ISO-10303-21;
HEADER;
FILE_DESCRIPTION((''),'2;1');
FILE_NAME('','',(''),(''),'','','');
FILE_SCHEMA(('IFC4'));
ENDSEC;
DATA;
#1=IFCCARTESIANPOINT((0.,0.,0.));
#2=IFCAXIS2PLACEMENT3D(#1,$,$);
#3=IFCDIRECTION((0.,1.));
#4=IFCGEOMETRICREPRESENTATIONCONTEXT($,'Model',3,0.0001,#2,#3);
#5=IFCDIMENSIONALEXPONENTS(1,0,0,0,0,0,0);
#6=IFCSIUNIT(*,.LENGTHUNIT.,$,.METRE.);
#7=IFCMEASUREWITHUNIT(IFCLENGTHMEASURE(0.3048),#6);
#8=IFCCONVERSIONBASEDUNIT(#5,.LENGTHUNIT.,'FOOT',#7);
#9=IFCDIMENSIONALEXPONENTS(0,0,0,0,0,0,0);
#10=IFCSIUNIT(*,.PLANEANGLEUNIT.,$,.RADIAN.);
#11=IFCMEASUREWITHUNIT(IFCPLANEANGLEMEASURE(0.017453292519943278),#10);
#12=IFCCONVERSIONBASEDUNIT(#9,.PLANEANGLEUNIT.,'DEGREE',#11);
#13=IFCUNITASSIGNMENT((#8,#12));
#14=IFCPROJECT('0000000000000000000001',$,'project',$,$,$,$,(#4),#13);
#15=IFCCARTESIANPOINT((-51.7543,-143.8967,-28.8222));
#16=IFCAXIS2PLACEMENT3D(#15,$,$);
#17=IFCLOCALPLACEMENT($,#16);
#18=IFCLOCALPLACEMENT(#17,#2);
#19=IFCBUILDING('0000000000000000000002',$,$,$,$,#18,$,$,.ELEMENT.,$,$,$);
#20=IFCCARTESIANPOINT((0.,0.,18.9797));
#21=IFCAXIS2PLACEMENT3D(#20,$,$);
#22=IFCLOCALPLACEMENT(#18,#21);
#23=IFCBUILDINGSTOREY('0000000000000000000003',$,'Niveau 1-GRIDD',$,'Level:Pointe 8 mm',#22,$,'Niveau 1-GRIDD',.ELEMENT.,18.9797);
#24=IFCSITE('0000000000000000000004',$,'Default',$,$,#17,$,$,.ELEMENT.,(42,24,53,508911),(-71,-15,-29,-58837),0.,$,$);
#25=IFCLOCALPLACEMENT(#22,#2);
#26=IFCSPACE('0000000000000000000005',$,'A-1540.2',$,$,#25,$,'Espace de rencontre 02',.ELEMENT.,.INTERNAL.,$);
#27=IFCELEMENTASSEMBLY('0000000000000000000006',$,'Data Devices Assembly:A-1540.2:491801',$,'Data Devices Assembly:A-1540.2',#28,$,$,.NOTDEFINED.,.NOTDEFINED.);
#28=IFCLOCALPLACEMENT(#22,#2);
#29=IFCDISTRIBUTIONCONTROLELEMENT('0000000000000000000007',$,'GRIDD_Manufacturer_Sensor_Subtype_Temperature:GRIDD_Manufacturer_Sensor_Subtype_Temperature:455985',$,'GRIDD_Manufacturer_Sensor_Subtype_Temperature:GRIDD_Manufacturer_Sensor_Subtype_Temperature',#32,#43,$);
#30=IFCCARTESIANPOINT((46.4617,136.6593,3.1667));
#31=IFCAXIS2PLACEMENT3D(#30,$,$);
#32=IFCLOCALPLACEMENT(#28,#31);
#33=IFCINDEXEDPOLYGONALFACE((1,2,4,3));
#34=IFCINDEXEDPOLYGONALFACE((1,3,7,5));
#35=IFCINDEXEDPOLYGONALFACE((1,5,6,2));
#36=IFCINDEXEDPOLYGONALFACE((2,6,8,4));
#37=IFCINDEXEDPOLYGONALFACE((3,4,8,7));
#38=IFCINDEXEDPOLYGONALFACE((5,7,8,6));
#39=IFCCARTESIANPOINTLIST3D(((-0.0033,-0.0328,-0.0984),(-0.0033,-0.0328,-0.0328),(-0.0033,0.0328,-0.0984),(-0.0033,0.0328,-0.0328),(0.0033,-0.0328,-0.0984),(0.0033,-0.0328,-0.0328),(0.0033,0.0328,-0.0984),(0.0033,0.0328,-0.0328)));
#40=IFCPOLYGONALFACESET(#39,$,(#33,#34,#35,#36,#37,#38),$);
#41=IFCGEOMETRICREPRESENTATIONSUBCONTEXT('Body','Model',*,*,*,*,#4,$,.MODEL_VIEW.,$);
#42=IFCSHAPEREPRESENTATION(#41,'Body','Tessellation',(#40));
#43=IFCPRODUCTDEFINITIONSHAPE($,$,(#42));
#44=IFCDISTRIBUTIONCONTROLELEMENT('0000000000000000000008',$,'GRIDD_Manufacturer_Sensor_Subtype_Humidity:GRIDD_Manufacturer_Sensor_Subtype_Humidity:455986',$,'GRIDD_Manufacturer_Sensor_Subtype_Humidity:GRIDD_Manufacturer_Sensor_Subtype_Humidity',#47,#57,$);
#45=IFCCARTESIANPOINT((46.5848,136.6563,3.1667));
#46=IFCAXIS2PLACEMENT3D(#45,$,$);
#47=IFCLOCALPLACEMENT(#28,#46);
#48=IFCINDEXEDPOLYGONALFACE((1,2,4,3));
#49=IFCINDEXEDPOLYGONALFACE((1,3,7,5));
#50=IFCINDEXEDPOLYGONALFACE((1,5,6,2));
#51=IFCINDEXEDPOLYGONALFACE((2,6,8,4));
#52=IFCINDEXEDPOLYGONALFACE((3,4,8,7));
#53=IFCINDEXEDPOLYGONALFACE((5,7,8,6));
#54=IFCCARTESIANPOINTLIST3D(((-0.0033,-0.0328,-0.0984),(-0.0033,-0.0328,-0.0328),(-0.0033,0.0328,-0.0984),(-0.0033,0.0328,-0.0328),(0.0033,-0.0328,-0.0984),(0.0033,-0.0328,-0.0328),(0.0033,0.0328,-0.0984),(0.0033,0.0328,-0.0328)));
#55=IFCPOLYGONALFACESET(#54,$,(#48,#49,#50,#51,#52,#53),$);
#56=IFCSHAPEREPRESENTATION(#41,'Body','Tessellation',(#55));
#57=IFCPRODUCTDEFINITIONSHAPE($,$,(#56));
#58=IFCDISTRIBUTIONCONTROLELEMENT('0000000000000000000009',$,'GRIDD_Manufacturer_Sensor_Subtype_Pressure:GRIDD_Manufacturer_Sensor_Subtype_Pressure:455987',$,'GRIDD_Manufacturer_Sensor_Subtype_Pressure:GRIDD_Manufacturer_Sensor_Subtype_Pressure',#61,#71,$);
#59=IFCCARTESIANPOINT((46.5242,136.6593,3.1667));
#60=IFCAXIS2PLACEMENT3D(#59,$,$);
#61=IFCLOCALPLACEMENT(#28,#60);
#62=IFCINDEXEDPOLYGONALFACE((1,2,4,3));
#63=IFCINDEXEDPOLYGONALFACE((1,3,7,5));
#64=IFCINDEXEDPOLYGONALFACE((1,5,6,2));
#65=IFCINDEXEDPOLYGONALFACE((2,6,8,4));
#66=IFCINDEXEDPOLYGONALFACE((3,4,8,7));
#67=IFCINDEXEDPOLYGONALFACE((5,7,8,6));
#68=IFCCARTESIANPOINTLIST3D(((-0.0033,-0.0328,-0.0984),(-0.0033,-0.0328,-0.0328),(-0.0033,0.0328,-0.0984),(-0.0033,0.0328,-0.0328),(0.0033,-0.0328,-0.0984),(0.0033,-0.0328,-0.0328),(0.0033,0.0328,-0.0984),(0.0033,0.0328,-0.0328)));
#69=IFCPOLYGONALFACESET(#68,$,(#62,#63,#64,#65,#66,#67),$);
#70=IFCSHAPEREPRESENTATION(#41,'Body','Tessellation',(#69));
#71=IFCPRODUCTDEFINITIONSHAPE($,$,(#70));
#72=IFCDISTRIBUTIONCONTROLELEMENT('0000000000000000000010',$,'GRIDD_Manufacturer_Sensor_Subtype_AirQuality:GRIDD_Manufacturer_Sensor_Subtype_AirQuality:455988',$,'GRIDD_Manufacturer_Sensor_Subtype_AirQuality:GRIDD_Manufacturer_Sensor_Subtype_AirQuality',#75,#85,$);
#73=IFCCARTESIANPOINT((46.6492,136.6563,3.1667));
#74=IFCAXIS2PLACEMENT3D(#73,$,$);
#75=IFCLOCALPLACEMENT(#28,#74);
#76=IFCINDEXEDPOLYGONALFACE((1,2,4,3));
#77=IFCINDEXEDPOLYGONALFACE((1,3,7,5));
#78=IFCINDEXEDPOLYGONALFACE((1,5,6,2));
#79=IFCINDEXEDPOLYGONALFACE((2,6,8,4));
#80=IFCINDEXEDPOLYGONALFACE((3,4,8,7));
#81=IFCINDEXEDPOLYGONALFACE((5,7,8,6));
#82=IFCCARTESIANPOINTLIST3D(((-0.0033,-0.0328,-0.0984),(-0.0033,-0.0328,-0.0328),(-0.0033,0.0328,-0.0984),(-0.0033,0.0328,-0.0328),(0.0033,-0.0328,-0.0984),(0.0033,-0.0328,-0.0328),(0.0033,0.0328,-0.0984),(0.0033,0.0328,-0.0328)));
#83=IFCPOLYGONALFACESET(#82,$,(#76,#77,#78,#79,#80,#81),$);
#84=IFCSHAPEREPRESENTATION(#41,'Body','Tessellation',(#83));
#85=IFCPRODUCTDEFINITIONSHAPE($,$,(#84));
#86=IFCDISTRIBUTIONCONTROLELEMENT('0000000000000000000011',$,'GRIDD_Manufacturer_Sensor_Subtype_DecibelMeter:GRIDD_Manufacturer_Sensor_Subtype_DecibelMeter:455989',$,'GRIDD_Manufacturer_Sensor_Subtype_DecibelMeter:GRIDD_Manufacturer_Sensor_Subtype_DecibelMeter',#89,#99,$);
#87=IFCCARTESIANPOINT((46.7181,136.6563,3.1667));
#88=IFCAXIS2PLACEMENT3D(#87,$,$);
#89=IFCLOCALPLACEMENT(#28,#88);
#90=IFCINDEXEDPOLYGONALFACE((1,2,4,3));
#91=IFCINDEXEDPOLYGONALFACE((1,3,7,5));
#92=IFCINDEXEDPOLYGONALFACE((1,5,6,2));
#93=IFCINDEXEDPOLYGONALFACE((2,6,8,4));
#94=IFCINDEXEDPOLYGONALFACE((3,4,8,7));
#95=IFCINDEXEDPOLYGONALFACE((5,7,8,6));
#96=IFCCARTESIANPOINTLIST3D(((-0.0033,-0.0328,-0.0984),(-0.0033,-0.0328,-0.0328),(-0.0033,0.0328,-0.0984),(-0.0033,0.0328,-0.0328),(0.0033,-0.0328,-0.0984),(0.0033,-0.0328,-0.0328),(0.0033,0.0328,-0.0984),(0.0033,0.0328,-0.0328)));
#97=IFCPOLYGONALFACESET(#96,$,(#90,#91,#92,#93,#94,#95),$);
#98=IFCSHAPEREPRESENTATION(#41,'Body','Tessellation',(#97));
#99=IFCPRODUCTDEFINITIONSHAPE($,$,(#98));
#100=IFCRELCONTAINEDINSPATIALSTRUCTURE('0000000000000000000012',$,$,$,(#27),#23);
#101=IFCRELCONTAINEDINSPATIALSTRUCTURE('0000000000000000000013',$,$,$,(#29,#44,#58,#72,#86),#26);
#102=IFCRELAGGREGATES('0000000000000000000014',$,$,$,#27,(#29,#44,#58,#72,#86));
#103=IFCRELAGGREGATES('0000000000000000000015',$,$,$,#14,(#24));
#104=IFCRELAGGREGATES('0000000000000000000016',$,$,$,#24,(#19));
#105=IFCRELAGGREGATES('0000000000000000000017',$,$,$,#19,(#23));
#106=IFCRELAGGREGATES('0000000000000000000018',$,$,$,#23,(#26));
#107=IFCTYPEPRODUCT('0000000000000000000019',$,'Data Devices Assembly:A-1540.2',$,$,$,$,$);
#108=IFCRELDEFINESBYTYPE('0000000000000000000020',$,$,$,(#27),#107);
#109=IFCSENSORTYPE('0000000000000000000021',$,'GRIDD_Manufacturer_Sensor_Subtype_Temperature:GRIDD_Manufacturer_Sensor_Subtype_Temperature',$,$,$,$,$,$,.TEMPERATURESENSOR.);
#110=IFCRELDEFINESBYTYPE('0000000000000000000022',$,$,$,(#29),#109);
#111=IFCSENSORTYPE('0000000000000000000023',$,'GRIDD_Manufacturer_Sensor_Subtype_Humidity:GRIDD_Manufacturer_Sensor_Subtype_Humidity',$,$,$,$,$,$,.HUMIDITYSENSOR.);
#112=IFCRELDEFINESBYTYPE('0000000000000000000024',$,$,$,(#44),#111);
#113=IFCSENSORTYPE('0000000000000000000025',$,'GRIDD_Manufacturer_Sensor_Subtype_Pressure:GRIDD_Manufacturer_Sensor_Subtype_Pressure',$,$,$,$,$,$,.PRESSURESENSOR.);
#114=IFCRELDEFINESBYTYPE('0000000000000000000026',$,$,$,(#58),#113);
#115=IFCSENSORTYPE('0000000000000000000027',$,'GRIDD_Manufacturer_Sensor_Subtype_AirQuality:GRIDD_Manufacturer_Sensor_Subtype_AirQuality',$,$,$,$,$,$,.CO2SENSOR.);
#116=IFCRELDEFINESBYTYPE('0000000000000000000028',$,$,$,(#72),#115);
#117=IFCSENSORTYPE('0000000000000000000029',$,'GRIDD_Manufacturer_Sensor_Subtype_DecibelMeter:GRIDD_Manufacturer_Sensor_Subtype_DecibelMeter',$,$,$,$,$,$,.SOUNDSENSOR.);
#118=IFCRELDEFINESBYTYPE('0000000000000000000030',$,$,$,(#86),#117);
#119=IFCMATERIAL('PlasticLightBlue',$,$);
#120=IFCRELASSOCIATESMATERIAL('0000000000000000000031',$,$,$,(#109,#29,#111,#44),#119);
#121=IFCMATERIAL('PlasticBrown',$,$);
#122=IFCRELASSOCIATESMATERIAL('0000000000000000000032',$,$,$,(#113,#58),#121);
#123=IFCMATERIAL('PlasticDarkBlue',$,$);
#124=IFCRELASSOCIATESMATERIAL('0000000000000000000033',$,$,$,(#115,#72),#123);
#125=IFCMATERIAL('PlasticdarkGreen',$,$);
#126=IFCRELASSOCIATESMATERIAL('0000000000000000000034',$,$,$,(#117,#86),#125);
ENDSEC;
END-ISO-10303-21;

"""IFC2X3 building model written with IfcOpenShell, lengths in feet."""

from ifc_helpers import new_model, entity, si_unit, converted_unit, direction, frame, origin, origin_2d_with_axis, place, context, subcontext, project, spatial, rectangle, extrude, source, transform, mapped, material, type_object, type_shapes, element, aggregate, save


model = new_model("IFC2X3")

# Units and contexts
model_context = context("Model", 3, precision=0.0001, world=origin(), true_north=direction((0.0, 1.0)))
body_context = subcontext(model_context, "Body", "Model", "MODEL_VIEW")
ifc_project = project(units=[converted_unit("LENGTHUNIT", "FOOT", entity("IfcLengthMeasure", 0.3048), si_unit("LENGTHUNIT", "METRE"), dimensions=[1, 0, 0, 0, 0, 0, 0]), converted_unit("PLANEANGLEUNIT", "DEGREE", entity("IfcPlaneAngleMeasure", 0.017453292519943278), si_unit("PLANEANGLEUNIT", "RADIAN"), dimensions=[0, 0, 0, 0, 0, 0, 0])], contexts=[model_context])

# Site, building, storey
site_placement = place(None, frame((-51.7543, -143.8967, -28.8222)))
site = spatial("IfcSite", under=ifc_project, at=site_placement, Name="Default", CompositionType="ELEMENT", RefLatitude=(42, 24, 53, 508911), RefLongitude=(-71, -15, -29, -58837), RefElevation=0.0)
building_placement = place(site_placement, origin())
building = spatial("IfcBuilding", under=site, at=building_placement, CompositionType="ELEMENT")
storey_placement = place(building_placement, frame((0.0, 0.0, 18.9797)))
storey = spatial("IfcBuildingStorey", under=building, at=storey_placement, Name="Niveau 1-GRIDD", ObjectType="Level:Pointe 8 mm", LongName="Niveau 1-GRIDD", CompositionType="ELEMENT", Elevation=18.9797)

# Shared definitions
space_1_placement = place(storey_placement, origin())
space_1 = spatial("IfcSpace", under=storey, at=space_1_placement, Name="A-1540.2", LongName="Espace de rencontre 02", CompositionType="ELEMENT", InteriorOrExteriorSpace="INTERNAL")

# Element assembly, distribution control elements
type_product = type_object("IfcTypeProduct", Name="Data Devices Assembly:A-1540.2")
assembly_placement = place(storey_placement, origin())
assembly = element("IfcElementAssembly", 1, at=assembly_placement, inside=storey, type_object=type_product, Name="Data Devices Assembly:A-1540.2:491801", ObjectType="Data Devices Assembly:A-1540.2", AssemblyPlace="NOTDEFINED", PredefinedType="NOTDEFINED")
ifc_material_1 = material(Name="PlasticLightBlue")
sensor_type_1 = type_object("IfcSensorType", Name="GRIDD_Manufacturer_Sensor_Subtype_Temperature:GRIDD_Manufacturer_Sensor_Subtype_Temperature", PredefinedType="TEMPERATURESENSOR", material=ifc_material_1)
shared_shape_1 = source(origin(), body_context, "Body", "SweptSolid", [
    extrude(rectangle(XDim=0.0066, YDim=0.0656, at=origin_2d_with_axis()), frame((0.0, 0.0, -0.0984), z_axis=(0.0, 0.0, 1.0), x_axis=(-1.0, 0.0, 0.0)), (0.0, 0.0, 1.0), 0.0656),
])
type_shapes(sensor_type_1, [shared_shape_1])
distribution_control_element_1_placement = place(assembly_placement, frame((46.4617, 136.6593, 3.1667)))
distribution_control_element_1 = element("IfcDistributionControlElement", 2, at=distribution_control_element_1_placement, inside=space_1, type_object=sensor_type_1, material=ifc_material_1, Name="GRIDD_Manufacturer_Sensor_Subtype_Temperature:GRIDD_Manufacturer_Sensor_Subtype_Temperature:455985", ObjectType="GRIDD_Manufacturer_Sensor_Subtype_Temperature:GRIDD_Manufacturer_Sensor_Subtype_Temperature", context=body_context, shape_type="MappedRepresentation", body=[
    mapped(shared_shape_1, transform((0.0, 0.0, 0.0), scale=1.0)),
])
sensor_type_2 = type_object("IfcSensorType", Name="GRIDD_Manufacturer_Sensor_Subtype_Humidity:GRIDD_Manufacturer_Sensor_Subtype_Humidity", PredefinedType="HUMIDITYSENSOR", material=ifc_material_1)
shared_shape_2 = source(origin(), body_context, "Body", "SweptSolid", [
    extrude(rectangle(XDim=0.0066, YDim=0.0656, at=origin_2d_with_axis()), frame((0.0, 0.0, -0.0984), z_axis=(0.0, 0.0, 1.0), x_axis=(-1.0, 0.0, 0.0)), (0.0, 0.0, 1.0), 0.0656),
])
type_shapes(sensor_type_2, [shared_shape_2])
distribution_control_element_2_placement = place(assembly_placement, frame((46.5848, 136.6563, 3.1667)))
distribution_control_element_2 = element("IfcDistributionControlElement", 3, at=distribution_control_element_2_placement, inside=space_1, type_object=sensor_type_2, material=ifc_material_1, Name="GRIDD_Manufacturer_Sensor_Subtype_Humidity:GRIDD_Manufacturer_Sensor_Subtype_Humidity:455986", ObjectType="GRIDD_Manufacturer_Sensor_Subtype_Humidity:GRIDD_Manufacturer_Sensor_Subtype_Humidity", context=body_context, shape_type="MappedRepresentation", body=[
    mapped(shared_shape_2, transform((0.0, 0.0, 0.0), scale=1.0)),
])
ifc_material_2 = material(Name="PlasticBrown")
sensor_type_3 = type_object("IfcSensorType", Name="GRIDD_Manufacturer_Sensor_Subtype_Pressure:GRIDD_Manufacturer_Sensor_Subtype_Pressure", PredefinedType="PRESSURESENSOR", material=ifc_material_2)
shared_shape_3 = source(origin(), body_context, "Body", "SweptSolid", [
    extrude(rectangle(XDim=0.0066, YDim=0.0656, at=origin_2d_with_axis()), frame((0.0, 0.0, -0.0984), z_axis=(0.0, 0.0, 1.0), x_axis=(-1.0, 0.0, 0.0)), (0.0, 0.0, 1.0), 0.0656),
])
type_shapes(sensor_type_3, [shared_shape_3])
distribution_control_element_3_placement = place(assembly_placement, frame((46.5242, 136.6593, 3.1667)))
distribution_control_element_3 = element("IfcDistributionControlElement", 4, at=distribution_control_element_3_placement, inside=space_1, type_object=sensor_type_3, material=ifc_material_2, Name="GRIDD_Manufacturer_Sensor_Subtype_Pressure:GRIDD_Manufacturer_Sensor_Subtype_Pressure:455987", ObjectType="GRIDD_Manufacturer_Sensor_Subtype_Pressure:GRIDD_Manufacturer_Sensor_Subtype_Pressure", context=body_context, shape_type="MappedRepresentation", body=[
    mapped(shared_shape_3, transform((0.0, 0.0, 0.0), scale=1.0)),
])
ifc_material_3 = material(Name="PlasticDarkBlue")
sensor_type_4 = type_object("IfcSensorType", Name="GRIDD_Manufacturer_Sensor_Subtype_AirQuality:GRIDD_Manufacturer_Sensor_Subtype_AirQuality", PredefinedType="CO2SENSOR", material=ifc_material_3)
shared_shape_4 = source(origin(), body_context, "Body", "SweptSolid", [
    extrude(rectangle(XDim=0.0066, YDim=0.0656, at=origin_2d_with_axis()), frame((0.0, 0.0, -0.0984), z_axis=(0.0, 0.0, 1.0), x_axis=(-1.0, 0.0, 0.0)), (0.0, 0.0, 1.0), 0.0656),
])
type_shapes(sensor_type_4, [shared_shape_4])
distribution_control_element_4_placement = place(assembly_placement, frame((46.6492, 136.6563, 3.1667)))
distribution_control_element_4 = element("IfcDistributionControlElement", 5, at=distribution_control_element_4_placement, inside=space_1, type_object=sensor_type_4, material=ifc_material_3, Name="GRIDD_Manufacturer_Sensor_Subtype_AirQuality:GRIDD_Manufacturer_Sensor_Subtype_AirQuality:455988", ObjectType="GRIDD_Manufacturer_Sensor_Subtype_AirQuality:GRIDD_Manufacturer_Sensor_Subtype_AirQuality", context=body_context, shape_type="MappedRepresentation", body=[
    mapped(shared_shape_4, transform((0.0, 0.0, 0.0), scale=1.0)),
])
ifc_material_4 = material(Name="PlasticdarkGreen")
sensor_type_5 = type_object("IfcSensorType", Name="GRIDD_Manufacturer_Sensor_Subtype_DecibelMeter:GRIDD_Manufacturer_Sensor_Subtype_DecibelMeter", PredefinedType="SOUNDSENSOR", material=ifc_material_4)
shared_shape_5 = source(origin(), body_context, "Body", "SweptSolid", [
    extrude(rectangle(XDim=0.0066, YDim=0.0656, at=origin_2d_with_axis()), frame((0.0, 0.0, -0.0984), z_axis=(0.0, 0.0, 1.0), x_axis=(-1.0, 0.0, 0.0)), (0.0, 0.0, 1.0), 0.0656),
])
type_shapes(sensor_type_5, [shared_shape_5])
distribution_control_element_5_placement = place(assembly_placement, frame((46.7181, 136.6563, 3.1667)))
distribution_control_element_5 = element("IfcDistributionControlElement", 6, at=distribution_control_element_5_placement, inside=space_1, type_object=sensor_type_5, material=ifc_material_4, Name="GRIDD_Manufacturer_Sensor_Subtype_DecibelMeter:GRIDD_Manufacturer_Sensor_Subtype_DecibelMeter:455989", ObjectType="GRIDD_Manufacturer_Sensor_Subtype_DecibelMeter:GRIDD_Manufacturer_Sensor_Subtype_DecibelMeter", context=body_context, shape_type="MappedRepresentation", body=[
    mapped(shared_shape_5, transform((0.0, 0.0, 0.0), scale=1.0)),
])
aggregate(assembly, [distribution_control_element_1, distribution_control_element_2, distribution_control_element_3, distribution_control_element_4, distribution_control_element_5])

save(model, "model.ifc")
